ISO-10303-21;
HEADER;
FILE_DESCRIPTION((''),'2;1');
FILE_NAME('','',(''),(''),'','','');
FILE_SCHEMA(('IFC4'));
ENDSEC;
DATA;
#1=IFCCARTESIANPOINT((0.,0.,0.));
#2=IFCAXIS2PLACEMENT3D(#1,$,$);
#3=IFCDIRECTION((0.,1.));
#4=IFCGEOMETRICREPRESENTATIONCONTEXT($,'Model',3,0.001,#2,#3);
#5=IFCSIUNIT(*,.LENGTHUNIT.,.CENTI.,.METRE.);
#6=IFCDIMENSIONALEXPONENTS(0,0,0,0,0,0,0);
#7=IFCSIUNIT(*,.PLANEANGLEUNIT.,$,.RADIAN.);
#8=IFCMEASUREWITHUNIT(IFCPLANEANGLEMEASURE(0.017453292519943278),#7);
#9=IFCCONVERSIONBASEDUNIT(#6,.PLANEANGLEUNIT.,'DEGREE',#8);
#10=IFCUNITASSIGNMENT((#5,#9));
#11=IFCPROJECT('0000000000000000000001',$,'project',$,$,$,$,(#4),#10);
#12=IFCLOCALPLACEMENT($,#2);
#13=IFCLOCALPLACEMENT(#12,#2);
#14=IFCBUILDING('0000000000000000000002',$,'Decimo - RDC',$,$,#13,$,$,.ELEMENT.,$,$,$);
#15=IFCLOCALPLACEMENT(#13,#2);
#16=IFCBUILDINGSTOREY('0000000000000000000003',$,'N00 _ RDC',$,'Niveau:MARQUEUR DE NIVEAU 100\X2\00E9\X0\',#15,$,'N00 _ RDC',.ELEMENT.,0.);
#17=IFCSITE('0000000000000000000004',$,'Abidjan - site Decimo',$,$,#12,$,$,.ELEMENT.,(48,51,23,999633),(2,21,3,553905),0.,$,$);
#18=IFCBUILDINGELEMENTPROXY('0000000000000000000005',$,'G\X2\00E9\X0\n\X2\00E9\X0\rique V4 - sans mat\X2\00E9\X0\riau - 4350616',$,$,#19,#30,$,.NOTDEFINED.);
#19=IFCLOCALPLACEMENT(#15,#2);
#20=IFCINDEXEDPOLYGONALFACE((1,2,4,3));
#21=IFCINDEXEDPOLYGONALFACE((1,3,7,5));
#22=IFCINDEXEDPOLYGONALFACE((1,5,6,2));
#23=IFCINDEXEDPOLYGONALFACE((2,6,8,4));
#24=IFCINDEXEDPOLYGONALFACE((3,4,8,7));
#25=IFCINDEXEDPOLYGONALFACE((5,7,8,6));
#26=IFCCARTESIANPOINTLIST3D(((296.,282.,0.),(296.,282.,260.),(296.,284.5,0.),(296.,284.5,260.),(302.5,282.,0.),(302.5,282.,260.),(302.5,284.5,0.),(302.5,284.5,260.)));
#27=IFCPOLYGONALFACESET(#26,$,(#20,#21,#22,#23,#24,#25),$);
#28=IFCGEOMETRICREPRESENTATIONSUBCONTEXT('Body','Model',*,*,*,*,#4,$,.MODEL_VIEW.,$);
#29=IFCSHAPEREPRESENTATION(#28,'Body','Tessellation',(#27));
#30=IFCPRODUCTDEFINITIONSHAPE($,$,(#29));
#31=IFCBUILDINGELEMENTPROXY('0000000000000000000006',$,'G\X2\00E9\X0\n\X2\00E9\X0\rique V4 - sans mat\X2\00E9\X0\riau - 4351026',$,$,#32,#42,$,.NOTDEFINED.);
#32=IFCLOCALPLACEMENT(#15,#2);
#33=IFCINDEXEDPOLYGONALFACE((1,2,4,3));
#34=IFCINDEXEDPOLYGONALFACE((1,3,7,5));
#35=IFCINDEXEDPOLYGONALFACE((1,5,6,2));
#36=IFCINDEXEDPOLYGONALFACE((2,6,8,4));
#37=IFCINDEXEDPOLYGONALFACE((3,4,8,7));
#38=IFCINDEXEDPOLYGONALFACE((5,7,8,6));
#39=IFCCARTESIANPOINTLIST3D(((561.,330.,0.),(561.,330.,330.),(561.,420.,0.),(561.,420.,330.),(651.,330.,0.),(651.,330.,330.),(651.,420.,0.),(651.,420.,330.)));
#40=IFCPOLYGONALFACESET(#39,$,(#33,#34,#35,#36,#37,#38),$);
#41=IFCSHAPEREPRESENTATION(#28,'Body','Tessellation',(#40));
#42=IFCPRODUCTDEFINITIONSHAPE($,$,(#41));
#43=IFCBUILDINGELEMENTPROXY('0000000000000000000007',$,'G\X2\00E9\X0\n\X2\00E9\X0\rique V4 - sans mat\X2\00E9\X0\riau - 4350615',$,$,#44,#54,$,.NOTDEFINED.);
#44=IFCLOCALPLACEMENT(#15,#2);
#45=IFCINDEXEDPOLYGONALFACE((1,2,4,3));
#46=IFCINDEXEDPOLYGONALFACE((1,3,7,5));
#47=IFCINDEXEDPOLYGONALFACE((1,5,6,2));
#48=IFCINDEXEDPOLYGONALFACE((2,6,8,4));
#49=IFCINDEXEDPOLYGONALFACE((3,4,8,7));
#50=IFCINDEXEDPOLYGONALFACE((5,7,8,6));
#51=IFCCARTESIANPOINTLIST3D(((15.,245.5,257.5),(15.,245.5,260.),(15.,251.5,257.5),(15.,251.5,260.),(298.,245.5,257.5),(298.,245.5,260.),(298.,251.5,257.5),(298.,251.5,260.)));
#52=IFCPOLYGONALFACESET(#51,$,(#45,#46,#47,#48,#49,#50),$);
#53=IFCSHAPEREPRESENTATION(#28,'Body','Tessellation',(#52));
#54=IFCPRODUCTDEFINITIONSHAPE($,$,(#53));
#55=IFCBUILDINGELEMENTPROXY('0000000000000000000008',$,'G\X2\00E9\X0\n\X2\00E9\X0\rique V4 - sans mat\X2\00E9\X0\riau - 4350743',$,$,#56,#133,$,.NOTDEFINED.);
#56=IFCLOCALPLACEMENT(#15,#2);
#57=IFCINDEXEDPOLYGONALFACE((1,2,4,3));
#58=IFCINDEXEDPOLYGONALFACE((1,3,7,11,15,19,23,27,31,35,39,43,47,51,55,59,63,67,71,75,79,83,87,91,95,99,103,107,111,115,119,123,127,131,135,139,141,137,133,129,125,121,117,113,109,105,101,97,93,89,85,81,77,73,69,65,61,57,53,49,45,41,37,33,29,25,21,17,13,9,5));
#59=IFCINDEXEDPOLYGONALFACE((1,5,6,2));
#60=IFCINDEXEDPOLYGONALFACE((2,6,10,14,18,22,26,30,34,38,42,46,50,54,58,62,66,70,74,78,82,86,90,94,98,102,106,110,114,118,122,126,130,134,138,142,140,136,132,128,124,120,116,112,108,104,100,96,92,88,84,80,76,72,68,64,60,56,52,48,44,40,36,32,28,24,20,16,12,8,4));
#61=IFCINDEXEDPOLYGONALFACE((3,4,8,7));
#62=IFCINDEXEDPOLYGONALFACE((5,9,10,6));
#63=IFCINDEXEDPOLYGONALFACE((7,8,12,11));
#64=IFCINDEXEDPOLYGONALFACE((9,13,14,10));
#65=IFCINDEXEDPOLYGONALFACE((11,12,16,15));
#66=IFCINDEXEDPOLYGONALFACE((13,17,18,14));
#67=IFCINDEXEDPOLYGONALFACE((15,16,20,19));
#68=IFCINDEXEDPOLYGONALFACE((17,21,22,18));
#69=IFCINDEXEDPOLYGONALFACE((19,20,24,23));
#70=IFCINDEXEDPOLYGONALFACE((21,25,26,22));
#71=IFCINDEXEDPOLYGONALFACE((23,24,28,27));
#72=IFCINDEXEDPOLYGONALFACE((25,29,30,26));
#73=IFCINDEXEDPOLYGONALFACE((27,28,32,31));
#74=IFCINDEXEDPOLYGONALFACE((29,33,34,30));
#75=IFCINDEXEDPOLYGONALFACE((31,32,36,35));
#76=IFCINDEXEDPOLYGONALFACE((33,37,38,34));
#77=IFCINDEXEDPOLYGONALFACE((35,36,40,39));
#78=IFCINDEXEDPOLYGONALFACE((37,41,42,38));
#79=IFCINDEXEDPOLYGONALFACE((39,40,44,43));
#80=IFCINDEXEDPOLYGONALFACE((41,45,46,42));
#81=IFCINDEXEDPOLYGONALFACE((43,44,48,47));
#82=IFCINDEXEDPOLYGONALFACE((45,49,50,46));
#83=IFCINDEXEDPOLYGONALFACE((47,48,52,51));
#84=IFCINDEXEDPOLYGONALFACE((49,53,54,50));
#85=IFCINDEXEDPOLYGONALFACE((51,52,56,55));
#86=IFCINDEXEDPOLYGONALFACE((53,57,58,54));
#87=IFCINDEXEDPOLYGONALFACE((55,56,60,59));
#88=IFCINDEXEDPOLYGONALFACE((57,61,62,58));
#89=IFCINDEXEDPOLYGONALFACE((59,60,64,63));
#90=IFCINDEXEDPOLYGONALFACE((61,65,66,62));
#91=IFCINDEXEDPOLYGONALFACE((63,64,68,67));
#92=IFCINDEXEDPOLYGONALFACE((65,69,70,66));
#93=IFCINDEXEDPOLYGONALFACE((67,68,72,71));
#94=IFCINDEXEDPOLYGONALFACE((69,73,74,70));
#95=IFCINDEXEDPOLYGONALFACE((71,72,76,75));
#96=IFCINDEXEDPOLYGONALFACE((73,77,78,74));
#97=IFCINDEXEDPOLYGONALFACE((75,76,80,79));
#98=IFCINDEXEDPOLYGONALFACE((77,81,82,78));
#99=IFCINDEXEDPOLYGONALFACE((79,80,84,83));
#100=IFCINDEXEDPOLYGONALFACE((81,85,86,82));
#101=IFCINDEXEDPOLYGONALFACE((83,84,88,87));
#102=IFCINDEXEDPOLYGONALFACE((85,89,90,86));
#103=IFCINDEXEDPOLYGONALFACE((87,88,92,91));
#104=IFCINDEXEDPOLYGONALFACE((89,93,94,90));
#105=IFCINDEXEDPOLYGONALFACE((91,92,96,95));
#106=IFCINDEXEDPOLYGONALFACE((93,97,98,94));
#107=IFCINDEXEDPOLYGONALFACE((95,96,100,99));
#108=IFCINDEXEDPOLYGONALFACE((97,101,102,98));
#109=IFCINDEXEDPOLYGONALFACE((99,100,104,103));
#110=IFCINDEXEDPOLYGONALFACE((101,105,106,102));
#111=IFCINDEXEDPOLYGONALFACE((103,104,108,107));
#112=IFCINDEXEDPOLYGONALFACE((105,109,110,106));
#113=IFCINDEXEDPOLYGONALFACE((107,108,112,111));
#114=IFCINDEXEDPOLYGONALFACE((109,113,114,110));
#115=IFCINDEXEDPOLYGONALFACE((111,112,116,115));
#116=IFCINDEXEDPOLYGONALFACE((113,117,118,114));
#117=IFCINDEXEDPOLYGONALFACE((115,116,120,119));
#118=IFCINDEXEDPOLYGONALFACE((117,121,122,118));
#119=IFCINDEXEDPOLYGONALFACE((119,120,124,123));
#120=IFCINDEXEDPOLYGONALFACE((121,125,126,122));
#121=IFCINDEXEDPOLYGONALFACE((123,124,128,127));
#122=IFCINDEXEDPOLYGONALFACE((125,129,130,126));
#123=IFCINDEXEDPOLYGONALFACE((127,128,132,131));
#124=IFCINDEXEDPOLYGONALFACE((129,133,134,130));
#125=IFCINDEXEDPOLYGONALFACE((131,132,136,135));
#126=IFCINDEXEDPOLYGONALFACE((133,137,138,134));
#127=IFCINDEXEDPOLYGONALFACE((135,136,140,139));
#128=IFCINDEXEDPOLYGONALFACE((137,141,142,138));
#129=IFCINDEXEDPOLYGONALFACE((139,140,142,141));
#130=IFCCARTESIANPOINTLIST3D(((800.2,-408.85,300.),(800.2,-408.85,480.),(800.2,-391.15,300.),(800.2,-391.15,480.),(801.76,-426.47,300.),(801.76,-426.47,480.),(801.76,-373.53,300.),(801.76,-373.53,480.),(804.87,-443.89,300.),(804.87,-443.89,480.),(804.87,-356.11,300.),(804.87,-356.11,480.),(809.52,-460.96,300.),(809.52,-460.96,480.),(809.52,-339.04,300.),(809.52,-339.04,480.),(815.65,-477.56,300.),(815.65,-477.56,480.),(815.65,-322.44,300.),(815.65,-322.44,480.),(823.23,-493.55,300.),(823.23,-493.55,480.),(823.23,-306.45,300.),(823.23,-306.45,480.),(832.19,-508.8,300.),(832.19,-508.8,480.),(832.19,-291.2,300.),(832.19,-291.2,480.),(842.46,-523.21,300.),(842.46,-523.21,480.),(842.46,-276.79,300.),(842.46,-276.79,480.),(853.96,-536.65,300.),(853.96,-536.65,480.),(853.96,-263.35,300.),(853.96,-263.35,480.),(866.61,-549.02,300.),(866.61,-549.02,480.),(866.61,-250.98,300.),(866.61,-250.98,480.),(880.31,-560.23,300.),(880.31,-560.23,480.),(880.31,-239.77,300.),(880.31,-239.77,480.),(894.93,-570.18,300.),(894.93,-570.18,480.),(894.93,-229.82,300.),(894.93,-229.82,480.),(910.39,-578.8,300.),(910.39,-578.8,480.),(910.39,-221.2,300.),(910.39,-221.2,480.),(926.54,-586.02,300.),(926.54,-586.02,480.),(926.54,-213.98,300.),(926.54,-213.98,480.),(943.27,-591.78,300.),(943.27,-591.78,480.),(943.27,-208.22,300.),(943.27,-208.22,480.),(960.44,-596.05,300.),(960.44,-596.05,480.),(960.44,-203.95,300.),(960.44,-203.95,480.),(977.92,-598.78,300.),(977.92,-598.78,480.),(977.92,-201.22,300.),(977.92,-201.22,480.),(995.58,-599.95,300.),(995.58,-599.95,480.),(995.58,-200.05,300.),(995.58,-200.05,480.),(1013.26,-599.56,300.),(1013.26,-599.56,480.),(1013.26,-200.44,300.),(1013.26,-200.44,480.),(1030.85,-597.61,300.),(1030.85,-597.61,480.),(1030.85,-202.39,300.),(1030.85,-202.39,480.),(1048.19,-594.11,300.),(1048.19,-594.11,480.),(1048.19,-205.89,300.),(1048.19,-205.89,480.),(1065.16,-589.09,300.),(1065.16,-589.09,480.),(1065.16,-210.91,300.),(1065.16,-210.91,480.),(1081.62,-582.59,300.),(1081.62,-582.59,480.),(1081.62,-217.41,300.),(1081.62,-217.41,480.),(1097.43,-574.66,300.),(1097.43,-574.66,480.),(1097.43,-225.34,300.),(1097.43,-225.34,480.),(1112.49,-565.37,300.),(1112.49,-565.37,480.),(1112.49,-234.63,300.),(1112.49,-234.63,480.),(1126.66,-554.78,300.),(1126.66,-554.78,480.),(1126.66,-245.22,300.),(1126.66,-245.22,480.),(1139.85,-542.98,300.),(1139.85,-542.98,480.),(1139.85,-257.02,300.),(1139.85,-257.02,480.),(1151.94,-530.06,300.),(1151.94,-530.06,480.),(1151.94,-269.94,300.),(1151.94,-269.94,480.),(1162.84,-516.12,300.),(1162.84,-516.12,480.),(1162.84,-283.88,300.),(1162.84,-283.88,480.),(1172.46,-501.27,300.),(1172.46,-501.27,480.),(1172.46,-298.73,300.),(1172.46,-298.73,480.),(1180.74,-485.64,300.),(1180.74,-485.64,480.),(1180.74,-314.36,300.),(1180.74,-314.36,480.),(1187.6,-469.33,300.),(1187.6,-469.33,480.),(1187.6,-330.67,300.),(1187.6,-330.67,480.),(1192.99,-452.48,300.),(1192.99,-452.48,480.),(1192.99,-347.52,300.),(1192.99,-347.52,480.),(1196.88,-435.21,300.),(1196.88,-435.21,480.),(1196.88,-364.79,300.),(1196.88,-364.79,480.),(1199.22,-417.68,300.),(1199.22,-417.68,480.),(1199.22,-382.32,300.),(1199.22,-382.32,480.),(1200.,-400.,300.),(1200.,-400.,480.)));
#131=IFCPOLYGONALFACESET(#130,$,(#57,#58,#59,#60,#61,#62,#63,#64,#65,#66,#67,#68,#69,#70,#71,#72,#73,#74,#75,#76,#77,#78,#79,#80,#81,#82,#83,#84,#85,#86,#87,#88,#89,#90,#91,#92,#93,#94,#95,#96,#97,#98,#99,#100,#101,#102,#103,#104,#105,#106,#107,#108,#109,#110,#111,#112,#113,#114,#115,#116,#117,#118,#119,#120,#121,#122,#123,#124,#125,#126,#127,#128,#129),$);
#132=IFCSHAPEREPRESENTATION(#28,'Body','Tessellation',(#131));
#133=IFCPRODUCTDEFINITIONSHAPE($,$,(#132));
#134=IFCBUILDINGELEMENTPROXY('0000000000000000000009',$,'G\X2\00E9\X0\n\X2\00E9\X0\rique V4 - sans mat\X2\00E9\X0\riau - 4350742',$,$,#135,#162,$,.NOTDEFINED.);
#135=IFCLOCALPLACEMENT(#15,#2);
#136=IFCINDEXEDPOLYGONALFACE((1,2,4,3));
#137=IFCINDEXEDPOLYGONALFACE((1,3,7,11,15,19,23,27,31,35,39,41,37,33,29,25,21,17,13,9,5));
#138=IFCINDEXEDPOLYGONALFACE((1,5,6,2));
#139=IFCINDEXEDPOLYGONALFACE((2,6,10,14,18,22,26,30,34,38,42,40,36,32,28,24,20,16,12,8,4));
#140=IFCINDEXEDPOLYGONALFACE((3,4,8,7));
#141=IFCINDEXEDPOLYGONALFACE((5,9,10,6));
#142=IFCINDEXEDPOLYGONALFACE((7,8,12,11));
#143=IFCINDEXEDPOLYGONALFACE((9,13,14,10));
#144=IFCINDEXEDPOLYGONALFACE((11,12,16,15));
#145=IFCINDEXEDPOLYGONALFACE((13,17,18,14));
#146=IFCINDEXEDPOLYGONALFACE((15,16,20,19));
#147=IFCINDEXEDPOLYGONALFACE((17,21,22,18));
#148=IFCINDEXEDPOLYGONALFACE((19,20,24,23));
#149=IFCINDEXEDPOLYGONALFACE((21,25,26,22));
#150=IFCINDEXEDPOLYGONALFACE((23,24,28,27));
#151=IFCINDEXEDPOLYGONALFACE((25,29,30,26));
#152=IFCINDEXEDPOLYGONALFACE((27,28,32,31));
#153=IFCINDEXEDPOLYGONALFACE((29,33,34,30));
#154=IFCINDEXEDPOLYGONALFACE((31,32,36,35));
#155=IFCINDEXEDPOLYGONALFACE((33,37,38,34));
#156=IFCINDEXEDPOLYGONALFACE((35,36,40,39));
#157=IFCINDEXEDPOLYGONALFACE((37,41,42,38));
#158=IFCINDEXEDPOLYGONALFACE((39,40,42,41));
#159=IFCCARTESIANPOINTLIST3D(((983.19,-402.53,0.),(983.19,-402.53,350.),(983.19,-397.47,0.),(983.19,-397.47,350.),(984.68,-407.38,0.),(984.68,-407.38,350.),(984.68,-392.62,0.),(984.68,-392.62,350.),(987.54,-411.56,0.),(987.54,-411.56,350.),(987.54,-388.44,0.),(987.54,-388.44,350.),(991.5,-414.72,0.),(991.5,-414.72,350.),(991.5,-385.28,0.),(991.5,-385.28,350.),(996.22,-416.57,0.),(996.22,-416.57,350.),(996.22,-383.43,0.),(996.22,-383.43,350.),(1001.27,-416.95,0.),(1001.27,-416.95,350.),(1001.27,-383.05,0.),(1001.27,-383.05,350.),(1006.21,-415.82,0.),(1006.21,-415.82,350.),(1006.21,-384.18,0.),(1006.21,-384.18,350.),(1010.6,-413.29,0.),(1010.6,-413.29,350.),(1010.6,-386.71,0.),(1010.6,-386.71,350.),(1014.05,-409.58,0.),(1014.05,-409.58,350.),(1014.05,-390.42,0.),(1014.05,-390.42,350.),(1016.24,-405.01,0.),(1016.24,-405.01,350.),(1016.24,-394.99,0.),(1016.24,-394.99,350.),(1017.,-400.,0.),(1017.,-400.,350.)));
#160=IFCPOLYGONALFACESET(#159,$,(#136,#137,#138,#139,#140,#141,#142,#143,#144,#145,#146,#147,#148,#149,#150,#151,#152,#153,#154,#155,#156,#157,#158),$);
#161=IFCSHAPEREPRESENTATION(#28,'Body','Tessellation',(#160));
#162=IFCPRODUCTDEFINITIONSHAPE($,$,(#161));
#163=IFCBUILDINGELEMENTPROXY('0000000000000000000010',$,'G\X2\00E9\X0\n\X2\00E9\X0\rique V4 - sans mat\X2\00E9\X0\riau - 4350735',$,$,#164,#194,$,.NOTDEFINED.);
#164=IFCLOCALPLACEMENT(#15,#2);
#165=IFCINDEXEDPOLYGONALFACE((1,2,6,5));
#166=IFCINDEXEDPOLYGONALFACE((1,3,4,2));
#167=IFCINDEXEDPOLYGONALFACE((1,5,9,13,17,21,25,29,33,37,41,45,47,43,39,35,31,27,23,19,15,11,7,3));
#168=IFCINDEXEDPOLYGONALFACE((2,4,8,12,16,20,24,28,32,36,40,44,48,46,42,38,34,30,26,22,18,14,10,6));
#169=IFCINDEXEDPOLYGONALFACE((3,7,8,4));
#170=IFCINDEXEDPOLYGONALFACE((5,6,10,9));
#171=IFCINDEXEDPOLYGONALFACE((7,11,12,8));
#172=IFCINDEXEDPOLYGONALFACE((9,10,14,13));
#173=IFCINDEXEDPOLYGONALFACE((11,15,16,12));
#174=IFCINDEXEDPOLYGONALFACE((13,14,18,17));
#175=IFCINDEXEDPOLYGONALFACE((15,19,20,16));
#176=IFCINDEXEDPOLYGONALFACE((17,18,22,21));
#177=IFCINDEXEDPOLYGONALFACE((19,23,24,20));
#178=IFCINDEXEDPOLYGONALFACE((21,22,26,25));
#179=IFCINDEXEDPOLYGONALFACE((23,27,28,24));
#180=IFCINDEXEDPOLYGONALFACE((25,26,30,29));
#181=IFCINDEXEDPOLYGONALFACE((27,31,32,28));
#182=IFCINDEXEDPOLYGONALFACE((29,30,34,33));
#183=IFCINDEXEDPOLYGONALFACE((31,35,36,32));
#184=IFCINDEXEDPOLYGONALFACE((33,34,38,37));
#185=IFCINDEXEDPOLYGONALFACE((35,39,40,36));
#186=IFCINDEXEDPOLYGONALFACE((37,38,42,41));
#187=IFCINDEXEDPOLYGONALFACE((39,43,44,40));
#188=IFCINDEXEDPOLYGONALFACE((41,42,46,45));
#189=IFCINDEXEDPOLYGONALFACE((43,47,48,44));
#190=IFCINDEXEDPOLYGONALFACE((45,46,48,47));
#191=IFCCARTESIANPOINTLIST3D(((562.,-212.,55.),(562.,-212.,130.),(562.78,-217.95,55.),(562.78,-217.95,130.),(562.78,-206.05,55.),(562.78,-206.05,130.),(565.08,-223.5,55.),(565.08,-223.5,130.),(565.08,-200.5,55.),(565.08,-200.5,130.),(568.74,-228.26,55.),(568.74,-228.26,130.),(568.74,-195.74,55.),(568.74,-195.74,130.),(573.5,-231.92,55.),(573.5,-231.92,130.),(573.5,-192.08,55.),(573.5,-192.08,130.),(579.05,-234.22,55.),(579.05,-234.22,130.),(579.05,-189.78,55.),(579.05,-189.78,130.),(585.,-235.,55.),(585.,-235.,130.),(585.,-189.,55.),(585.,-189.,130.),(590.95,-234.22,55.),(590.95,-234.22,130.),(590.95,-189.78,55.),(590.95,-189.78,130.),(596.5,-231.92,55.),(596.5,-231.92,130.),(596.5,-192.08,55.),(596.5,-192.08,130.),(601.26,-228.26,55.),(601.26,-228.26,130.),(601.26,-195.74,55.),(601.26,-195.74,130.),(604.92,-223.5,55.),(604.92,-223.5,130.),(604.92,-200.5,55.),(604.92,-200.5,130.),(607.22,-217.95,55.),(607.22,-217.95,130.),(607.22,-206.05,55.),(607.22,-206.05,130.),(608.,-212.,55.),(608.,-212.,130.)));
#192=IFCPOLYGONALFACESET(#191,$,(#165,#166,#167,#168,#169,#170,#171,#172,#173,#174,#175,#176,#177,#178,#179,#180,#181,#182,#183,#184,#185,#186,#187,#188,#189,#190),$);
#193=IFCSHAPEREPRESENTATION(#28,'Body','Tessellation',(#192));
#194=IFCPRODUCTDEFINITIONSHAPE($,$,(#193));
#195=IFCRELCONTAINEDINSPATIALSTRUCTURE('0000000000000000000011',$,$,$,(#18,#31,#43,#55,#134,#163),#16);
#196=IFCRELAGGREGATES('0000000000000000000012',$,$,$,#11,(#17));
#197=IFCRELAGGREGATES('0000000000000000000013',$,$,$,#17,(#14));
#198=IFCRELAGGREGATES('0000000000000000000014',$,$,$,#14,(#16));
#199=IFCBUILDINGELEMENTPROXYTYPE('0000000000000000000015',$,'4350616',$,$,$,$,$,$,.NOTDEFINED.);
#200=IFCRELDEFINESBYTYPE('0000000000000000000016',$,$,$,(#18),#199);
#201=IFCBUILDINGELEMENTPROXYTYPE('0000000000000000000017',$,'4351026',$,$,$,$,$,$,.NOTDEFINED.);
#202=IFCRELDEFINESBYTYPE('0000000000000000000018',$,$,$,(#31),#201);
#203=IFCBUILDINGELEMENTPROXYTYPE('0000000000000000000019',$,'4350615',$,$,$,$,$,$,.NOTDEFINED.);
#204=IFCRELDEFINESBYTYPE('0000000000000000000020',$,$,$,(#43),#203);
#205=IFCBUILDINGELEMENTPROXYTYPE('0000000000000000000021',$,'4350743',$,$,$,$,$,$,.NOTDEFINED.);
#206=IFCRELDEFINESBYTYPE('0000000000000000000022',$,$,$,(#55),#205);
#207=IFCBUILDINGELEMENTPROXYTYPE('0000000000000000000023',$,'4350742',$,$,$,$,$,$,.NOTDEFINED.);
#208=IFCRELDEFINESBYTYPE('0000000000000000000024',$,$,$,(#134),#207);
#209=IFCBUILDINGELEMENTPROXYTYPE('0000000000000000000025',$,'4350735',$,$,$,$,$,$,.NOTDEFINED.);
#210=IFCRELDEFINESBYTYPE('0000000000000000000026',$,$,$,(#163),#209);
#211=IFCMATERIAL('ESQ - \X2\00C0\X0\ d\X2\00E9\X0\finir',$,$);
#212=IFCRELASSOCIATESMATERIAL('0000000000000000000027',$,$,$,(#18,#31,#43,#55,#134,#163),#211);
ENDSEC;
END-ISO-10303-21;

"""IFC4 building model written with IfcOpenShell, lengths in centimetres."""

from ifc_helpers import new_model, entity, si_unit, converted_unit, direction, frame, frame_2d, origin, origin_2d_with_axis, place, context, subcontext, project, spatial, rectangle, circle, extrude, material, type_object, element, save


model = new_model("IFC4")

# Units and contexts
model_context = context("Model", 3, precision=0.001, world=origin(), true_north=direction((0.0, 1.0)))
body_context = subcontext(model_context, "Body", "Model", "MODEL_VIEW")
ifc_project = project(units=[si_unit("LENGTHUNIT", "METRE", prefix="CENTI"), converted_unit("PLANEANGLEUNIT", "DEGREE", entity("IfcPlaneAngleMeasure", 0.017453292519943278), si_unit("PLANEANGLEUNIT", "RADIAN"), dimensions=[0, 0, 0, 0, 0, 0, 0])], contexts=[model_context])

# Site, building, storey
site_placement = place(None, origin())
site = spatial("IfcSite", under=ifc_project, at=site_placement, Name="Abidjan - site Decimo", CompositionType="ELEMENT", RefLatitude=(48, 51, 23, 999633), RefLongitude=(2, 21, 3, 553905), RefElevation=0.0)
building_placement = place(site_placement, origin())
building = spatial("IfcBuilding", under=site, at=building_placement, Name="Decimo - RDC", CompositionType="ELEMENT")
storey_placement = place(building_placement, origin())
storey = spatial("IfcBuildingStorey", under=building, at=storey_placement, Name="N00 _ RDC", ObjectType="Niveau:MARQUEUR DE NIVEAU 100é", LongName="N00 _ RDC", CompositionType="ELEMENT", Elevation=0.0)

# Building element proxies
ifc_material_1 = material(Name="ESQ - À définir")
building_element_proxy_type_1 = type_object("IfcBuildingElementProxyType", Name="4350616", PredefinedType="NOTDEFINED")
proxy_1_placement = place(storey_placement, origin())
element("IfcBuildingElementProxy", 1, at=proxy_1_placement, inside=storey, type_object=building_element_proxy_type_1, material=ifc_material_1, Name="Générique V4 - sans matériau - 4350616", PredefinedType="NOTDEFINED", context=body_context, shape_type="SweptSolid", body=[
    extrude(rectangle(XDim=6.5, YDim=2.5, at=frame_2d((0.0, 0.0), x_axis=(1.0, 0.0))), frame((299.25, 283.25, 0.0)), (0.0, 0.0, 1.0), 260.0),
])
building_element_proxy_type_2 = type_object("IfcBuildingElementProxyType", Name="4351026", PredefinedType="NOTDEFINED")
proxy_2_placement = place(storey_placement, origin())
element("IfcBuildingElementProxy", 2, at=proxy_2_placement, inside=storey, type_object=building_element_proxy_type_2, material=ifc_material_1, Name="Générique V4 - sans matériau - 4351026", PredefinedType="NOTDEFINED", context=body_context, shape_type="SweptSolid", body=[
    extrude(rectangle(XDim=90.0, YDim=90.0, at=frame_2d((0.0, 0.0), x_axis=(1.0, 0.0))), frame((606.0, 375.0, 0.0)), (0.0, 0.0, 1.0), 330.0),
])
building_element_proxy_type_3 = type_object("IfcBuildingElementProxyType", Name="4350615", PredefinedType="NOTDEFINED")
proxy_3_placement = place(storey_placement, origin())
element("IfcBuildingElementProxy", 3, at=proxy_3_placement, inside=storey, type_object=building_element_proxy_type_3, material=ifc_material_1, Name="Générique V4 - sans matériau - 4350615", PredefinedType="NOTDEFINED", context=body_context, shape_type="SweptSolid", body=[
    extrude(rectangle(XDim=283.0, YDim=6.0, at=frame_2d((0.0, 0.0), x_axis=(1.0, 0.0))), frame((156.5, 248.5, 257.5)), (0.0, 0.0, 1.0), 2.5),
])
building_element_proxy_type_4 = type_object("IfcBuildingElementProxyType", Name="4350743", PredefinedType="NOTDEFINED")
proxy_4_placement = place(storey_placement, origin())
element("IfcBuildingElementProxy", 4, at=proxy_4_placement, inside=storey, type_object=building_element_proxy_type_4, material=ifc_material_1, Name="Générique V4 - sans matériau - 4350743", PredefinedType="NOTDEFINED", context=body_context, shape_type="SweptSolid", body=[
    extrude(circle(Radius=200.0, at=origin_2d_with_axis()), frame((1000.0, -400.0, 300.0)), (0.0, 0.0, 1.0), 180.0),
])
building_element_proxy_type_5 = type_object("IfcBuildingElementProxyType", Name="4350742", PredefinedType="NOTDEFINED")
proxy_5_placement = place(storey_placement, origin())
element("IfcBuildingElementProxy", 5, at=proxy_5_placement, inside=storey, type_object=building_element_proxy_type_5, material=ifc_material_1, Name="Générique V4 - sans matériau - 4350742", PredefinedType="NOTDEFINED", context=body_context, shape_type="SweptSolid", body=[
    extrude(circle(Radius=17.0, at=origin_2d_with_axis()), frame((1000.0, -400.0, 0.0)), (0.0, 0.0, 1.0), 350.0),
])
building_element_proxy_type_6 = type_object("IfcBuildingElementProxyType", Name="4350735", PredefinedType="NOTDEFINED")
proxy_6_placement = place(storey_placement, origin())
element("IfcBuildingElementProxy", 6, at=proxy_6_placement, inside=storey, type_object=building_element_proxy_type_6, material=ifc_material_1, Name="Générique V4 - sans matériau - 4350735", PredefinedType="NOTDEFINED", context=body_context, shape_type="SweptSolid", body=[
    extrude(circle(Radius=23.0, at=origin_2d_with_axis()), frame((585.0, -212.0, 55.0)), (0.0, 0.0, 1.0), 75.0),
])

save(model, "model.ifc")
